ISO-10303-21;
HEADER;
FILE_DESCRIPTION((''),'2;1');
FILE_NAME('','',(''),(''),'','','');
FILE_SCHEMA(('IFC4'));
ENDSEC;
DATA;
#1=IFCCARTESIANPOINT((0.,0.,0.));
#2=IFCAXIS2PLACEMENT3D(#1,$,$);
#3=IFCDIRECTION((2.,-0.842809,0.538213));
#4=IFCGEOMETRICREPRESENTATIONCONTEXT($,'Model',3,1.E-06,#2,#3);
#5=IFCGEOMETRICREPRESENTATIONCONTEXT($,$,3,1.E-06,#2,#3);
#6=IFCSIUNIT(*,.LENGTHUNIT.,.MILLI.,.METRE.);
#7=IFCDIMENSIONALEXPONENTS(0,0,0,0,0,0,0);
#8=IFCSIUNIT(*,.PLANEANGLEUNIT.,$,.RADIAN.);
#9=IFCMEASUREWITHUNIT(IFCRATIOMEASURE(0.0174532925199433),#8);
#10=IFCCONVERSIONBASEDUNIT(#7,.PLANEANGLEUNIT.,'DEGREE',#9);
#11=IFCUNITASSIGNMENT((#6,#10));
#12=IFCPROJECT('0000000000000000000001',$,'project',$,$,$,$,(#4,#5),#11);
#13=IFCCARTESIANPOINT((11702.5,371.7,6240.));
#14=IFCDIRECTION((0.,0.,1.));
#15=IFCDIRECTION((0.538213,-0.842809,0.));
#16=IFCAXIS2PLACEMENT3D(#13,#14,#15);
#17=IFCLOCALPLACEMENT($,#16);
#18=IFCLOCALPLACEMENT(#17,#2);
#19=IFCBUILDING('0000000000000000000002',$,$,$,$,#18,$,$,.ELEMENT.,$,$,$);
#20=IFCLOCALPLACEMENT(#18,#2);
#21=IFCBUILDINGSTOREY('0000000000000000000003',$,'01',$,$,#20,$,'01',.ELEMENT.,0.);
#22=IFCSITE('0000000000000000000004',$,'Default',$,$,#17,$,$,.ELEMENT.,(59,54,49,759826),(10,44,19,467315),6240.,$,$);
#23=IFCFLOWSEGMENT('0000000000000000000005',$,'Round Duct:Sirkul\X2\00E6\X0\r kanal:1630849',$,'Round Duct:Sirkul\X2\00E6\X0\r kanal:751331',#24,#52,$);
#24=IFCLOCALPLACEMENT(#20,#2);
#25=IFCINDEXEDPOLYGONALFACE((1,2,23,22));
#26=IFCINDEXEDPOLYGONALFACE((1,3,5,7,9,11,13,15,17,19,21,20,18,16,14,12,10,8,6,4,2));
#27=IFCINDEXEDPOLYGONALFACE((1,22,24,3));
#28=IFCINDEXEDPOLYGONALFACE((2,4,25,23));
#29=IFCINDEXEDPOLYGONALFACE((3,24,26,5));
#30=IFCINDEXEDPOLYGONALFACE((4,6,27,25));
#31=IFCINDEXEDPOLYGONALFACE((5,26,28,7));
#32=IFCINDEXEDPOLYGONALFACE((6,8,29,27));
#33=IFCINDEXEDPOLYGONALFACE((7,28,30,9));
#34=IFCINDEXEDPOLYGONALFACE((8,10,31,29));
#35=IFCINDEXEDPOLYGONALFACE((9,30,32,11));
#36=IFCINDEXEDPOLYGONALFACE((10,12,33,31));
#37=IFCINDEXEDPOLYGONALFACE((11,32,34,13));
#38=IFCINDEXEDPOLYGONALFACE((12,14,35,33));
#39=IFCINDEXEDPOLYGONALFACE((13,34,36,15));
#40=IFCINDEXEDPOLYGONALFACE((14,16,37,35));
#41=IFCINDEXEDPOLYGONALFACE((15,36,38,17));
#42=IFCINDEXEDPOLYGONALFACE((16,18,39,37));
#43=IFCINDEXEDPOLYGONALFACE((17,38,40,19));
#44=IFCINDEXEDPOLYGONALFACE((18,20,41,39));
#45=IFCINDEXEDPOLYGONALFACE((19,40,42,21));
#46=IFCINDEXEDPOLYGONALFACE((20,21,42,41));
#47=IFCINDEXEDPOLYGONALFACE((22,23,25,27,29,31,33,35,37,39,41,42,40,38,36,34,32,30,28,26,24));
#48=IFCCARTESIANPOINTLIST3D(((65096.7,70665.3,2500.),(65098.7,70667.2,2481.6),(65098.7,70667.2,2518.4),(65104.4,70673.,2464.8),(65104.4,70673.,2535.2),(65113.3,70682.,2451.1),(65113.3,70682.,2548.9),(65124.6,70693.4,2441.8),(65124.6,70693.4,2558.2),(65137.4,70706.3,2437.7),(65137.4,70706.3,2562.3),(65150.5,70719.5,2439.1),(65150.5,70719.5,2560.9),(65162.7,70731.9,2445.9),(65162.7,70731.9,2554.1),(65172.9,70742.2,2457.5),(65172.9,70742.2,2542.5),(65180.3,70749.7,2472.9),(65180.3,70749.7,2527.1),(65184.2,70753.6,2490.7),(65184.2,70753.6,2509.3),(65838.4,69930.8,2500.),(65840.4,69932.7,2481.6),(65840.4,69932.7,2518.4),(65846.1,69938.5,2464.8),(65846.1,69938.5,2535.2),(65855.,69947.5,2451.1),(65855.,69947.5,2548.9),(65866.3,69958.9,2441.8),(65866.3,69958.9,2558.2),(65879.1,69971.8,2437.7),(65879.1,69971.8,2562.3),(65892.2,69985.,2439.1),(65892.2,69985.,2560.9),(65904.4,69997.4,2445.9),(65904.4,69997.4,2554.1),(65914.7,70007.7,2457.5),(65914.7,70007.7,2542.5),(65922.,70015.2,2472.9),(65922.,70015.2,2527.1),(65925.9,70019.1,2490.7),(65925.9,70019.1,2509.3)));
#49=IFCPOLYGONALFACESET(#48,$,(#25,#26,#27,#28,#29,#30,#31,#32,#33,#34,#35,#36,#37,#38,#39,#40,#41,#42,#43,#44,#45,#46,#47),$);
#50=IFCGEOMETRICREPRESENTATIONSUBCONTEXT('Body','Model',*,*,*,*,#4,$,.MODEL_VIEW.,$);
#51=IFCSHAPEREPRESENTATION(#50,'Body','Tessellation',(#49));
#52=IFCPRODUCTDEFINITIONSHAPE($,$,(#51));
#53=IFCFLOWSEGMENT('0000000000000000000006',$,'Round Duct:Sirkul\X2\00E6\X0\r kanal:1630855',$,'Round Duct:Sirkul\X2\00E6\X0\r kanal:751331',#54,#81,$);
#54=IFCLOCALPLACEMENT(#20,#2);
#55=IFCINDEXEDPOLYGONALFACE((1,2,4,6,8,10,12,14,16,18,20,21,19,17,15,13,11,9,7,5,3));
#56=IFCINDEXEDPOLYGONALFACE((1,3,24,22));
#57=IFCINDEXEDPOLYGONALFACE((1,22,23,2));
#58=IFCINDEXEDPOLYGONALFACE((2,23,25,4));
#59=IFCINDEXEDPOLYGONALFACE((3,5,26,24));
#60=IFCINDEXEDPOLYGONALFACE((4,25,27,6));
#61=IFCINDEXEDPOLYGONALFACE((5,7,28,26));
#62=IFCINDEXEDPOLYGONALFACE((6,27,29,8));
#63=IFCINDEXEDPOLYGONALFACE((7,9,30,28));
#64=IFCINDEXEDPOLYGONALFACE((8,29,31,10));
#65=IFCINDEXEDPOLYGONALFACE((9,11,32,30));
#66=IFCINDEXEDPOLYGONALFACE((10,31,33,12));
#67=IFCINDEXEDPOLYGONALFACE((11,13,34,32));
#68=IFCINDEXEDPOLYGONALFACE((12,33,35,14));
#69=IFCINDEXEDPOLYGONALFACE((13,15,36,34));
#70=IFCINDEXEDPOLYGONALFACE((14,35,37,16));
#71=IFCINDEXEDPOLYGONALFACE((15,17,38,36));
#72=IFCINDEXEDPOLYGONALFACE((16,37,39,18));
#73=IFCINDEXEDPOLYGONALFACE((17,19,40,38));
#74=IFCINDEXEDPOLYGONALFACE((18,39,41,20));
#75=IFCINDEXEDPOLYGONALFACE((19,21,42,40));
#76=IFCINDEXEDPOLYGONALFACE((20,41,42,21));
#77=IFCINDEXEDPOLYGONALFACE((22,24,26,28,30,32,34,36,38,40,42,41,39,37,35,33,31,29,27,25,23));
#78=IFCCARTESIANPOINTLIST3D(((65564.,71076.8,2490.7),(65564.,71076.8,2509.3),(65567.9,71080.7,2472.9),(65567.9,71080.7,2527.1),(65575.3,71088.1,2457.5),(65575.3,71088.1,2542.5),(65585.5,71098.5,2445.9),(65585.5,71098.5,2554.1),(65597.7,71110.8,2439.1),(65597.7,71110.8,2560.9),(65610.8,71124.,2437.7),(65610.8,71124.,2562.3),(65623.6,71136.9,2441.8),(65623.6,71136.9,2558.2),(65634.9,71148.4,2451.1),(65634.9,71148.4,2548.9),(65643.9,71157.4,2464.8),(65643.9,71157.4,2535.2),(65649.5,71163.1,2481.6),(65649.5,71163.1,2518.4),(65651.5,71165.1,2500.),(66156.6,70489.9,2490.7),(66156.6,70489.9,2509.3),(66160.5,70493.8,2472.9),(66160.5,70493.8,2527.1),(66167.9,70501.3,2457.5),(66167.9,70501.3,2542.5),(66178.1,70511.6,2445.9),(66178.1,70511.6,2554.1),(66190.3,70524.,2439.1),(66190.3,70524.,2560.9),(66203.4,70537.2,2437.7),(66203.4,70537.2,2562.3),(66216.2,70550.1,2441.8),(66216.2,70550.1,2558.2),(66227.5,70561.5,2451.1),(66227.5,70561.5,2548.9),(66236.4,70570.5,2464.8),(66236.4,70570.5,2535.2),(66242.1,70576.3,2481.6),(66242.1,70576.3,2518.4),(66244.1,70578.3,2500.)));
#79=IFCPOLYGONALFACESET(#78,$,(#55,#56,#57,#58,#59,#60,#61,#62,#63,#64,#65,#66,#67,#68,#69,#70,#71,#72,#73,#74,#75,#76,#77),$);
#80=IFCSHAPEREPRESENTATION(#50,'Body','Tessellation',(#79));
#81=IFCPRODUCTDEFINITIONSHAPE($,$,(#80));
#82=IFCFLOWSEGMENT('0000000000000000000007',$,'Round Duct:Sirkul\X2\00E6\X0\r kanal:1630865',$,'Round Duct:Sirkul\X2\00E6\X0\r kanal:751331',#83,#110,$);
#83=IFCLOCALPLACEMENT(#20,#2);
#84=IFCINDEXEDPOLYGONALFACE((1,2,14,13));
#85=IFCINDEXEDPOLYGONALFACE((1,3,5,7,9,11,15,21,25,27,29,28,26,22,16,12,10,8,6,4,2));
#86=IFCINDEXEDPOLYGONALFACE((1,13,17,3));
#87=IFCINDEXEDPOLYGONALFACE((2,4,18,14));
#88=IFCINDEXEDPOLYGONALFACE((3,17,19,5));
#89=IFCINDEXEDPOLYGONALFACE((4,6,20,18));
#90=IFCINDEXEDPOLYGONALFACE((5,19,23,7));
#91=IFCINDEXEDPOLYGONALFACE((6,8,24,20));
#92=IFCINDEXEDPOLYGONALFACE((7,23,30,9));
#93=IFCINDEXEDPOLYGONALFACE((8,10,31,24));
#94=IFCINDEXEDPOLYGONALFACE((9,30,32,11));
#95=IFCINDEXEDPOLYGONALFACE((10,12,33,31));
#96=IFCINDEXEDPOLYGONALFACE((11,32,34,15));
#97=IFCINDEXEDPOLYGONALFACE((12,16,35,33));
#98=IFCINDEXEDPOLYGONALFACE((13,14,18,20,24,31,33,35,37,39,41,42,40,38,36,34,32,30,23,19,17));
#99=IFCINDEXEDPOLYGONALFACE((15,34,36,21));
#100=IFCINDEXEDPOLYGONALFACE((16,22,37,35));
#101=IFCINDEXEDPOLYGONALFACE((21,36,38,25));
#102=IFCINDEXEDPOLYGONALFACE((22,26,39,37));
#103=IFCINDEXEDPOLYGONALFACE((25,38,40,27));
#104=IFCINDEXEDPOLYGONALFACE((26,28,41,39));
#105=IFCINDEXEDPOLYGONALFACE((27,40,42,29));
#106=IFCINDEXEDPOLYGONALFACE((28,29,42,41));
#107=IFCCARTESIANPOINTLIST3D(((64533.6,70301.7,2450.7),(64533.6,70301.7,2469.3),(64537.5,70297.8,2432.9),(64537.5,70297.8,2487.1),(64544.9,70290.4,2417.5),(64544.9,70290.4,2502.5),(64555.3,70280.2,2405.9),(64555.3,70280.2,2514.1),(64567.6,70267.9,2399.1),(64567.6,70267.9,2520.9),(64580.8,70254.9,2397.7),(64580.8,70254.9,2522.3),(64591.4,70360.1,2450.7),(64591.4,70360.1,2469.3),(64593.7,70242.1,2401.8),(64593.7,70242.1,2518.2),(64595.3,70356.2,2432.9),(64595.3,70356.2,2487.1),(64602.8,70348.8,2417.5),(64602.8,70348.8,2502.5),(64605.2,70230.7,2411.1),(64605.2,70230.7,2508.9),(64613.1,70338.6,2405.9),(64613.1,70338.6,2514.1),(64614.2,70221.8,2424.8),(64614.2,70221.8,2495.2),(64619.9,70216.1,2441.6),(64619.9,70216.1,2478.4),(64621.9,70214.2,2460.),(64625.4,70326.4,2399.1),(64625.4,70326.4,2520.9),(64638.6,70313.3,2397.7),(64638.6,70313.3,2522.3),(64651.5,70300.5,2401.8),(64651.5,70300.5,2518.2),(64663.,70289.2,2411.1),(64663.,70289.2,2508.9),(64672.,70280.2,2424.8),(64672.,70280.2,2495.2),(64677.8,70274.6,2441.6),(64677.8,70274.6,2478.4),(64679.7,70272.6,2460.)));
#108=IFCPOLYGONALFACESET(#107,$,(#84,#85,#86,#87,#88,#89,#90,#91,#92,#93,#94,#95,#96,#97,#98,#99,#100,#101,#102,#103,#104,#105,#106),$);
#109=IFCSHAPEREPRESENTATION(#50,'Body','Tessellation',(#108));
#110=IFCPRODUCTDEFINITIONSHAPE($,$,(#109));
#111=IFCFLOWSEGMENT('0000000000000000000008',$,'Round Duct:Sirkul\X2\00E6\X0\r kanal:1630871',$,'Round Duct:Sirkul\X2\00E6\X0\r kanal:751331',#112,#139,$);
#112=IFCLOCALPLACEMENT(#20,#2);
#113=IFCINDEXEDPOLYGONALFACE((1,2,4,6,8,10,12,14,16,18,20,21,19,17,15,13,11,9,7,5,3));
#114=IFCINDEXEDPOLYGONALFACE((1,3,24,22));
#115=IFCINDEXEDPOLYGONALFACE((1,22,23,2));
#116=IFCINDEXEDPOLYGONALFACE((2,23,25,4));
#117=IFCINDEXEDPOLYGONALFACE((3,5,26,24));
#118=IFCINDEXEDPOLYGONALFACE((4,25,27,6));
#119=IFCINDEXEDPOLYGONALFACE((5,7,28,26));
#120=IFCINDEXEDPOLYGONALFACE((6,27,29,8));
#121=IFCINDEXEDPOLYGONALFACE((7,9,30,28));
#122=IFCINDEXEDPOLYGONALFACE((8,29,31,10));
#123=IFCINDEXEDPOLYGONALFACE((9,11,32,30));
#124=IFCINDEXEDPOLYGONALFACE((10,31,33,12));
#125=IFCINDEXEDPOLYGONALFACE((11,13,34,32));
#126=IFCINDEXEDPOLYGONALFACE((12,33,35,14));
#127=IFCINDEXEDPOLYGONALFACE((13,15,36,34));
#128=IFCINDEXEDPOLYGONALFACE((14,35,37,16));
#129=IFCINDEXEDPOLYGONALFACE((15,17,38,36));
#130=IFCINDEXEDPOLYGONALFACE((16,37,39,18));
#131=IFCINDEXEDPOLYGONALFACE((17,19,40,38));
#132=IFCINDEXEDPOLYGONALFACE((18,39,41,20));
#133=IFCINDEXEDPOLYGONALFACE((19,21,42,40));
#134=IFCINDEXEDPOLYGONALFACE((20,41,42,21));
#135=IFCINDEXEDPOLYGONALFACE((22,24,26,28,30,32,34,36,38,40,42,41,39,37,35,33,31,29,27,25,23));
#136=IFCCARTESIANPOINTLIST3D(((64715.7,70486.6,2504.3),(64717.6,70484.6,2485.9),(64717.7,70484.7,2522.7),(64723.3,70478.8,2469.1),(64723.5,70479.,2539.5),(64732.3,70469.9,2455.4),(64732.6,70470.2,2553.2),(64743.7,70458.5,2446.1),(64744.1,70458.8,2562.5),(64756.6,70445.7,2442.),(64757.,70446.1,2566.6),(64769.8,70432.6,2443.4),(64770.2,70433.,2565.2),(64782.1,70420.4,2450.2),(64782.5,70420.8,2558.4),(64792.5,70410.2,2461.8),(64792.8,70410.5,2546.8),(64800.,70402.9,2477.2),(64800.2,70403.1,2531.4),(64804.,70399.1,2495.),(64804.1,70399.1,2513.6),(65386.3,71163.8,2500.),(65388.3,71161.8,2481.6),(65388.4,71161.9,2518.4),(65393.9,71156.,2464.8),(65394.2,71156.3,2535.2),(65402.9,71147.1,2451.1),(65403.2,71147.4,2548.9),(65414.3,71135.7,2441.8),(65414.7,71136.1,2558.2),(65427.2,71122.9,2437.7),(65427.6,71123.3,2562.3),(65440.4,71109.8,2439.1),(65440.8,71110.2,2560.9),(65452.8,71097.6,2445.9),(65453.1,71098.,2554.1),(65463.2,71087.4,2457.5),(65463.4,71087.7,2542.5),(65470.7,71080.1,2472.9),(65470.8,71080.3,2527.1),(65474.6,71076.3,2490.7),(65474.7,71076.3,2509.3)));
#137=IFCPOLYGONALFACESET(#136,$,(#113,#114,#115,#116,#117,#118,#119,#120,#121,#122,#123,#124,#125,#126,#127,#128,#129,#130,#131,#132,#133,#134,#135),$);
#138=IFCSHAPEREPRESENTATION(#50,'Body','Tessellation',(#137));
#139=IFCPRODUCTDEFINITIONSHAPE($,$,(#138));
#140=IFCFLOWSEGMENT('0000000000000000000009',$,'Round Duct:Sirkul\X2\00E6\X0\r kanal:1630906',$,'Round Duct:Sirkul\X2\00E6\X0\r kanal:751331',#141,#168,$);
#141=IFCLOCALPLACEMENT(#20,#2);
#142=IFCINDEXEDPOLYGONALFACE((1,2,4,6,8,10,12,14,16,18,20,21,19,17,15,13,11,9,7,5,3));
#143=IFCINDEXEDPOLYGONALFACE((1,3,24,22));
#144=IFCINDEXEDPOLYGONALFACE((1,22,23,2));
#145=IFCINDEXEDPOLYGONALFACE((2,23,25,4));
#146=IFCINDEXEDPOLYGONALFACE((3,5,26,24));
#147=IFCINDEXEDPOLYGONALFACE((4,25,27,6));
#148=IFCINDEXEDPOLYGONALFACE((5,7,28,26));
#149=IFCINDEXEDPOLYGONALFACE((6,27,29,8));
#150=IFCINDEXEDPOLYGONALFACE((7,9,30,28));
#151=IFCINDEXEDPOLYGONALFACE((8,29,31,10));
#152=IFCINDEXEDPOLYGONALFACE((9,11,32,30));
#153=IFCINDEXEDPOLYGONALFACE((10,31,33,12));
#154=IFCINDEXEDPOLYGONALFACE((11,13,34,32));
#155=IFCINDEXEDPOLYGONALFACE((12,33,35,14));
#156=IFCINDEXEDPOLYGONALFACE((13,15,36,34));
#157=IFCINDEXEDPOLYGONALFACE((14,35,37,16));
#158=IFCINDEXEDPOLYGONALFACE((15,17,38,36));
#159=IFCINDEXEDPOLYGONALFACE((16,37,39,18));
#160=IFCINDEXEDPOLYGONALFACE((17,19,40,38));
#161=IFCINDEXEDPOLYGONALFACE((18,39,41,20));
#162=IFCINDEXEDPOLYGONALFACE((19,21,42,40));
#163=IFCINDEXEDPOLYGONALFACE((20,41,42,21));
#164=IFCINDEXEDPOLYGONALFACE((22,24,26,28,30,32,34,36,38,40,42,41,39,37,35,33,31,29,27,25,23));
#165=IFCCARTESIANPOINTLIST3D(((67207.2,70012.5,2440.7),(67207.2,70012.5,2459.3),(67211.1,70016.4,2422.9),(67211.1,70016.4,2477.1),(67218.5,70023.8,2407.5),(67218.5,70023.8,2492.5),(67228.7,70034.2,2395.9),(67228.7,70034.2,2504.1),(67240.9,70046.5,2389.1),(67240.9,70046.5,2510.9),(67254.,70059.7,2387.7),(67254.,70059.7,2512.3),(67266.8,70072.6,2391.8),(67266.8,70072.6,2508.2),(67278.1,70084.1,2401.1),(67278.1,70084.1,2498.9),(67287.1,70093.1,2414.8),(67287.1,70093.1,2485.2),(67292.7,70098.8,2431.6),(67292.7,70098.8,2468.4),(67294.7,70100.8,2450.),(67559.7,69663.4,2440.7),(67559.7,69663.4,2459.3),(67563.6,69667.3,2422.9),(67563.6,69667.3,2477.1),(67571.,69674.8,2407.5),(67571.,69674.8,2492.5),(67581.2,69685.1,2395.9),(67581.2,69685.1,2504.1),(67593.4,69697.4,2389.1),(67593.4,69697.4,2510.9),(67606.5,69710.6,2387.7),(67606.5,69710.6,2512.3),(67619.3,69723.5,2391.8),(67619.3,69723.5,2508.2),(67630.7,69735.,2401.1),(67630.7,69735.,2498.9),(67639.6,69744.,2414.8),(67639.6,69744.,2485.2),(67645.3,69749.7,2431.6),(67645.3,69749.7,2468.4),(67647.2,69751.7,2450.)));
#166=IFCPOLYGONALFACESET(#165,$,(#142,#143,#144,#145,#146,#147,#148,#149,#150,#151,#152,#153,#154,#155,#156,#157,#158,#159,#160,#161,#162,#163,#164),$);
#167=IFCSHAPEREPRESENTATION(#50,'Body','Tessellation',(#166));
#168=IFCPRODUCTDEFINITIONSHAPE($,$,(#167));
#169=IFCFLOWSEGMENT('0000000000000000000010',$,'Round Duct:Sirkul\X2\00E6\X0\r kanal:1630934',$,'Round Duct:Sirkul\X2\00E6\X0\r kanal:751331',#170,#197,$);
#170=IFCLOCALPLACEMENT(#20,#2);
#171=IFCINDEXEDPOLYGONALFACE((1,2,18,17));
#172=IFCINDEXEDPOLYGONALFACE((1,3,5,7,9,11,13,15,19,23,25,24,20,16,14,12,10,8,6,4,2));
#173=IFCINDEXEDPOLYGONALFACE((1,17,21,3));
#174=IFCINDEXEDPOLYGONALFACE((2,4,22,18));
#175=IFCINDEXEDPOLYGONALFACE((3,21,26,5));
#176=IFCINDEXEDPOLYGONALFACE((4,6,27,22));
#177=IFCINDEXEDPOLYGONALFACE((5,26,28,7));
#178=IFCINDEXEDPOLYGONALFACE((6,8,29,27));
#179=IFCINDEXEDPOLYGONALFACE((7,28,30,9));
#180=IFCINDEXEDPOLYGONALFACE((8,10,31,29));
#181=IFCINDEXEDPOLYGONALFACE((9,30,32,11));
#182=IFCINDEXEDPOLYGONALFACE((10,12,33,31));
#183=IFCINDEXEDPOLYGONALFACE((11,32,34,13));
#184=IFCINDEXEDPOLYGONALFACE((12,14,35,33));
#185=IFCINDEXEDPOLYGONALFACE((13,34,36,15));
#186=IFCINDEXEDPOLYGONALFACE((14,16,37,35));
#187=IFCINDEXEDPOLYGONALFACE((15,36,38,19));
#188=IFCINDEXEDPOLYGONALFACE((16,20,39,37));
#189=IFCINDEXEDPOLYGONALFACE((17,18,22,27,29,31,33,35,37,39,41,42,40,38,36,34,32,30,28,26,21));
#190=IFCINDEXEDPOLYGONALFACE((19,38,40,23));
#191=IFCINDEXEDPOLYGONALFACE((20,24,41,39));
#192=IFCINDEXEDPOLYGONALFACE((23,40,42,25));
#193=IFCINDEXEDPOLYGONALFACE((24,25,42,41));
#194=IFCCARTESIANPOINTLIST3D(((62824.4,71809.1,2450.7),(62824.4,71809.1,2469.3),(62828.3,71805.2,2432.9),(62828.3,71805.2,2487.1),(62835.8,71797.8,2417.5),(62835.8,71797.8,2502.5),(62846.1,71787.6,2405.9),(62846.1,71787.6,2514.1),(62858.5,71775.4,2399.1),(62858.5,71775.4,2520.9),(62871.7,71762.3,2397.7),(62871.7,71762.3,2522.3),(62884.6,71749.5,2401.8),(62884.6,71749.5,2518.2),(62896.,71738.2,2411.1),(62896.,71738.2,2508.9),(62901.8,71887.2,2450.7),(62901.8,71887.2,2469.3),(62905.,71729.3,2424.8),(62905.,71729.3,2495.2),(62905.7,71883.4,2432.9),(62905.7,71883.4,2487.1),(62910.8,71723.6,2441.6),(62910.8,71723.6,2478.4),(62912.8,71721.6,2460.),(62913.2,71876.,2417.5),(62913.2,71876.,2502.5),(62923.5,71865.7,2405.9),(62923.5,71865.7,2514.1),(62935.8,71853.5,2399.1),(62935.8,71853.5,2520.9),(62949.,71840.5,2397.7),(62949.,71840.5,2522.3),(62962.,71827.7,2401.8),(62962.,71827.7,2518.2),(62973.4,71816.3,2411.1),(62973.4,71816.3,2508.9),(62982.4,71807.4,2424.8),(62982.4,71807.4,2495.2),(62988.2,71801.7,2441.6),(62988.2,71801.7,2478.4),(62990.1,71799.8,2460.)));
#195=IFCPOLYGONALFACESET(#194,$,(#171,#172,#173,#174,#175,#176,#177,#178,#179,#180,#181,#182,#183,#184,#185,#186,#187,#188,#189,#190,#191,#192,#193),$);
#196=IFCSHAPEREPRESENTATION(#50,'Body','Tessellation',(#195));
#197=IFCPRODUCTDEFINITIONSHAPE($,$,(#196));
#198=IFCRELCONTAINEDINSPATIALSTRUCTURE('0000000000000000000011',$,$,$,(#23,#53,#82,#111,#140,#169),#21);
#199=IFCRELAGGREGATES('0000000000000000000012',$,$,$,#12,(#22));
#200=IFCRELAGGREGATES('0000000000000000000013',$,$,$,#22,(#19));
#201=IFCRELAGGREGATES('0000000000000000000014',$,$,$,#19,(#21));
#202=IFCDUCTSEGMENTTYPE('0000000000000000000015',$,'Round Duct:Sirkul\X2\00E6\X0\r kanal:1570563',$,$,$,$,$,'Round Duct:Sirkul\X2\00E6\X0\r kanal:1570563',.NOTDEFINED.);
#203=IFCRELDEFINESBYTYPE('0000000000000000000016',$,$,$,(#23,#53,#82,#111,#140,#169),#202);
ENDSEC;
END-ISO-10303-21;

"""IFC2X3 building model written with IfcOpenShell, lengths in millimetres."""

from ifc_helpers import new_model, entity, si_unit, converted_unit, direction, frame, origin, origin_2d_with_axis, place, context, subcontext, project, spatial, circle, extrude, type_object, element, save


model = new_model("IFC2X3")

# Units and contexts
model_context = context("Model", 3, precision=1e-06, world=origin(), true_north=direction((2.0, -0.842809, 0.538213)))
context_of_model = context(None, 3, precision=1e-06, world=origin(), true_north=direction((2.0, -0.842809, 0.538213)))
body_context = subcontext(model_context, "Body", "Model", "MODEL_VIEW")
ifc_project = project(units=[si_unit("LENGTHUNIT", "METRE", prefix="MILLI"), converted_unit("PLANEANGLEUNIT", "DEGREE", entity("IfcRatioMeasure", 0.0174532925199433), si_unit("PLANEANGLEUNIT", "RADIAN"), dimensions=[0, 0, 0, 0, 0, 0, 0])], contexts=[model_context, context_of_model])

# Site, building, storey
site_placement = place(None, frame((11702.5, 371.7, 6240.0), z_axis=(0.0, 0.0, 1.0), x_axis=(0.538213, -0.842809, 0.0)))
site = spatial("IfcSite", under=ifc_project, at=site_placement, Name="Default", CompositionType="ELEMENT", RefLatitude=(59, 54, 49, 759826), RefLongitude=(10, 44, 19, 467315), RefElevation=6240.0)
building_placement = place(site_placement, origin())
building = spatial("IfcBuilding", under=site, at=building_placement, CompositionType="ELEMENT")
storey_placement = place(building_placement, origin())
storey = spatial("IfcBuildingStorey", under=building, at=storey_placement, Name="01", LongName="01", CompositionType="ELEMENT", Elevation=0.0)

# Flow segments
duct_segment_type = type_object("IfcDuctSegmentType", Name="Round Duct:Sirkulær kanal:1570563", ElementType="Round Duct:Sirkulær kanal:1570563", PredefinedType="NOTDEFINED")
flow_segment_1_placement = place(storey_placement, origin())
element("IfcFlowSegment", 1, at=flow_segment_1_placement, inside=storey, type_object=duct_segment_type, Name="Round Duct:Sirkulær kanal:1630849", ObjectType="Round Duct:Sirkulær kanal:751331", context=body_context, shape_type="SweptSolid", body=[
    extrude(circle(Radius=62.5, at=origin_2d_with_axis()), frame((65140.7, 70709.7, 2500.0), z_axis=(0.710554, -0.703643, 0.0), x_axis=(-0.703643, -0.710554, 0.0)), (0.0, 0.0, 1.0), 1043.9),
])
flow_segment_2_placement = place(storey_placement, origin())
element("IfcFlowSegment", 2, at=flow_segment_2_placement, inside=storey, type_object=duct_segment_type, Name="Round Duct:Sirkulær kanal:1630855", ObjectType="Round Duct:Sirkulær kanal:751331", context=body_context, shape_type="SweptSolid", body=[
    extrude(circle(Radius=62.5, at=origin_2d_with_axis()), frame((66200.1, 70533.8, 2500.0), z_axis=(-0.710554, 0.703643, 0.0), x_axis=(0.703643, 0.710554, 0.0)), (0.0, 0.0, 1.0), 834.0),
])
flow_segment_3_placement = place(storey_placement, origin())
element("IfcFlowSegment", 3, at=flow_segment_3_placement, inside=storey, type_object=duct_segment_type, Name="Round Duct:Sirkulær kanal:1630865", ObjectType="Round Duct:Sirkulær kanal:751331", context=body_context, shape_type="SweptSolid", body=[
    extrude(circle(Radius=62.5, at=origin_2d_with_axis()), frame((64577.5, 70258.2, 2460.0), z_axis=(0.703646, 0.710551, 0.0), x_axis=(0.710551, -0.703646, 0.0)), (0.0, 0.0, 1.0), 82.2),
])
flow_segment_4_placement = place(storey_placement, origin())
element("IfcFlowSegment", 4, at=flow_segment_4_placement, inside=storey, type_object=duct_segment_type, Name="Round Duct:Sirkulær kanal:1630871", ObjectType="Round Duct:Sirkulær kanal:751331", context=body_context, shape_type="SweptSolid", body=[
    extrude(circle(Radius=62.5, at=origin_2d_with_axis()), frame((64760.1, 70442.6, 2504.3), z_axis=(0.703641, 0.710541, -0.004522), x_axis=(-0.710549, 0.703648, 0.0)), (0.0, 0.0, 1.0), 953.1),
])
flow_segment_5_placement = place(storey_placement, origin())
element("IfcFlowSegment", 5, at=flow_segment_5_placement, inside=storey, type_object=duct_segment_type, Name="Round Duct:Sirkulær kanal:1630906", ObjectType="Round Duct:Sirkulær kanal:751331", context=body_context, shape_type="SweptSolid", body=[
    extrude(circle(Radius=62.5, at=origin_2d_with_axis()), frame((67250.7, 70056.4, 2450.0), z_axis=(0.710554, -0.703643, 0.0), x_axis=(0.703643, 0.710554, 0.0)), (0.0, 0.0, 1.0), 496.1),
])
flow_segment_6_placement = place(storey_placement, origin())
element("IfcFlowSegment", 6, at=flow_segment_6_placement, inside=storey, type_object=duct_segment_type, Name="Round Duct:Sirkulær kanal:1630934", ObjectType="Round Duct:Sirkulær kanal:751331", context=body_context, shape_type="SweptSolid", body=[
    extrude(circle(Radius=62.5, at=origin_2d_with_axis()), frame((62868.4, 71765.6, 2460.0), z_axis=(0.703642, 0.710555, 0.0), x_axis=(0.710555, -0.703642, 0.0)), (0.0, 0.0, 1.0), 110.0),
])

save(model, "model.ifc")
